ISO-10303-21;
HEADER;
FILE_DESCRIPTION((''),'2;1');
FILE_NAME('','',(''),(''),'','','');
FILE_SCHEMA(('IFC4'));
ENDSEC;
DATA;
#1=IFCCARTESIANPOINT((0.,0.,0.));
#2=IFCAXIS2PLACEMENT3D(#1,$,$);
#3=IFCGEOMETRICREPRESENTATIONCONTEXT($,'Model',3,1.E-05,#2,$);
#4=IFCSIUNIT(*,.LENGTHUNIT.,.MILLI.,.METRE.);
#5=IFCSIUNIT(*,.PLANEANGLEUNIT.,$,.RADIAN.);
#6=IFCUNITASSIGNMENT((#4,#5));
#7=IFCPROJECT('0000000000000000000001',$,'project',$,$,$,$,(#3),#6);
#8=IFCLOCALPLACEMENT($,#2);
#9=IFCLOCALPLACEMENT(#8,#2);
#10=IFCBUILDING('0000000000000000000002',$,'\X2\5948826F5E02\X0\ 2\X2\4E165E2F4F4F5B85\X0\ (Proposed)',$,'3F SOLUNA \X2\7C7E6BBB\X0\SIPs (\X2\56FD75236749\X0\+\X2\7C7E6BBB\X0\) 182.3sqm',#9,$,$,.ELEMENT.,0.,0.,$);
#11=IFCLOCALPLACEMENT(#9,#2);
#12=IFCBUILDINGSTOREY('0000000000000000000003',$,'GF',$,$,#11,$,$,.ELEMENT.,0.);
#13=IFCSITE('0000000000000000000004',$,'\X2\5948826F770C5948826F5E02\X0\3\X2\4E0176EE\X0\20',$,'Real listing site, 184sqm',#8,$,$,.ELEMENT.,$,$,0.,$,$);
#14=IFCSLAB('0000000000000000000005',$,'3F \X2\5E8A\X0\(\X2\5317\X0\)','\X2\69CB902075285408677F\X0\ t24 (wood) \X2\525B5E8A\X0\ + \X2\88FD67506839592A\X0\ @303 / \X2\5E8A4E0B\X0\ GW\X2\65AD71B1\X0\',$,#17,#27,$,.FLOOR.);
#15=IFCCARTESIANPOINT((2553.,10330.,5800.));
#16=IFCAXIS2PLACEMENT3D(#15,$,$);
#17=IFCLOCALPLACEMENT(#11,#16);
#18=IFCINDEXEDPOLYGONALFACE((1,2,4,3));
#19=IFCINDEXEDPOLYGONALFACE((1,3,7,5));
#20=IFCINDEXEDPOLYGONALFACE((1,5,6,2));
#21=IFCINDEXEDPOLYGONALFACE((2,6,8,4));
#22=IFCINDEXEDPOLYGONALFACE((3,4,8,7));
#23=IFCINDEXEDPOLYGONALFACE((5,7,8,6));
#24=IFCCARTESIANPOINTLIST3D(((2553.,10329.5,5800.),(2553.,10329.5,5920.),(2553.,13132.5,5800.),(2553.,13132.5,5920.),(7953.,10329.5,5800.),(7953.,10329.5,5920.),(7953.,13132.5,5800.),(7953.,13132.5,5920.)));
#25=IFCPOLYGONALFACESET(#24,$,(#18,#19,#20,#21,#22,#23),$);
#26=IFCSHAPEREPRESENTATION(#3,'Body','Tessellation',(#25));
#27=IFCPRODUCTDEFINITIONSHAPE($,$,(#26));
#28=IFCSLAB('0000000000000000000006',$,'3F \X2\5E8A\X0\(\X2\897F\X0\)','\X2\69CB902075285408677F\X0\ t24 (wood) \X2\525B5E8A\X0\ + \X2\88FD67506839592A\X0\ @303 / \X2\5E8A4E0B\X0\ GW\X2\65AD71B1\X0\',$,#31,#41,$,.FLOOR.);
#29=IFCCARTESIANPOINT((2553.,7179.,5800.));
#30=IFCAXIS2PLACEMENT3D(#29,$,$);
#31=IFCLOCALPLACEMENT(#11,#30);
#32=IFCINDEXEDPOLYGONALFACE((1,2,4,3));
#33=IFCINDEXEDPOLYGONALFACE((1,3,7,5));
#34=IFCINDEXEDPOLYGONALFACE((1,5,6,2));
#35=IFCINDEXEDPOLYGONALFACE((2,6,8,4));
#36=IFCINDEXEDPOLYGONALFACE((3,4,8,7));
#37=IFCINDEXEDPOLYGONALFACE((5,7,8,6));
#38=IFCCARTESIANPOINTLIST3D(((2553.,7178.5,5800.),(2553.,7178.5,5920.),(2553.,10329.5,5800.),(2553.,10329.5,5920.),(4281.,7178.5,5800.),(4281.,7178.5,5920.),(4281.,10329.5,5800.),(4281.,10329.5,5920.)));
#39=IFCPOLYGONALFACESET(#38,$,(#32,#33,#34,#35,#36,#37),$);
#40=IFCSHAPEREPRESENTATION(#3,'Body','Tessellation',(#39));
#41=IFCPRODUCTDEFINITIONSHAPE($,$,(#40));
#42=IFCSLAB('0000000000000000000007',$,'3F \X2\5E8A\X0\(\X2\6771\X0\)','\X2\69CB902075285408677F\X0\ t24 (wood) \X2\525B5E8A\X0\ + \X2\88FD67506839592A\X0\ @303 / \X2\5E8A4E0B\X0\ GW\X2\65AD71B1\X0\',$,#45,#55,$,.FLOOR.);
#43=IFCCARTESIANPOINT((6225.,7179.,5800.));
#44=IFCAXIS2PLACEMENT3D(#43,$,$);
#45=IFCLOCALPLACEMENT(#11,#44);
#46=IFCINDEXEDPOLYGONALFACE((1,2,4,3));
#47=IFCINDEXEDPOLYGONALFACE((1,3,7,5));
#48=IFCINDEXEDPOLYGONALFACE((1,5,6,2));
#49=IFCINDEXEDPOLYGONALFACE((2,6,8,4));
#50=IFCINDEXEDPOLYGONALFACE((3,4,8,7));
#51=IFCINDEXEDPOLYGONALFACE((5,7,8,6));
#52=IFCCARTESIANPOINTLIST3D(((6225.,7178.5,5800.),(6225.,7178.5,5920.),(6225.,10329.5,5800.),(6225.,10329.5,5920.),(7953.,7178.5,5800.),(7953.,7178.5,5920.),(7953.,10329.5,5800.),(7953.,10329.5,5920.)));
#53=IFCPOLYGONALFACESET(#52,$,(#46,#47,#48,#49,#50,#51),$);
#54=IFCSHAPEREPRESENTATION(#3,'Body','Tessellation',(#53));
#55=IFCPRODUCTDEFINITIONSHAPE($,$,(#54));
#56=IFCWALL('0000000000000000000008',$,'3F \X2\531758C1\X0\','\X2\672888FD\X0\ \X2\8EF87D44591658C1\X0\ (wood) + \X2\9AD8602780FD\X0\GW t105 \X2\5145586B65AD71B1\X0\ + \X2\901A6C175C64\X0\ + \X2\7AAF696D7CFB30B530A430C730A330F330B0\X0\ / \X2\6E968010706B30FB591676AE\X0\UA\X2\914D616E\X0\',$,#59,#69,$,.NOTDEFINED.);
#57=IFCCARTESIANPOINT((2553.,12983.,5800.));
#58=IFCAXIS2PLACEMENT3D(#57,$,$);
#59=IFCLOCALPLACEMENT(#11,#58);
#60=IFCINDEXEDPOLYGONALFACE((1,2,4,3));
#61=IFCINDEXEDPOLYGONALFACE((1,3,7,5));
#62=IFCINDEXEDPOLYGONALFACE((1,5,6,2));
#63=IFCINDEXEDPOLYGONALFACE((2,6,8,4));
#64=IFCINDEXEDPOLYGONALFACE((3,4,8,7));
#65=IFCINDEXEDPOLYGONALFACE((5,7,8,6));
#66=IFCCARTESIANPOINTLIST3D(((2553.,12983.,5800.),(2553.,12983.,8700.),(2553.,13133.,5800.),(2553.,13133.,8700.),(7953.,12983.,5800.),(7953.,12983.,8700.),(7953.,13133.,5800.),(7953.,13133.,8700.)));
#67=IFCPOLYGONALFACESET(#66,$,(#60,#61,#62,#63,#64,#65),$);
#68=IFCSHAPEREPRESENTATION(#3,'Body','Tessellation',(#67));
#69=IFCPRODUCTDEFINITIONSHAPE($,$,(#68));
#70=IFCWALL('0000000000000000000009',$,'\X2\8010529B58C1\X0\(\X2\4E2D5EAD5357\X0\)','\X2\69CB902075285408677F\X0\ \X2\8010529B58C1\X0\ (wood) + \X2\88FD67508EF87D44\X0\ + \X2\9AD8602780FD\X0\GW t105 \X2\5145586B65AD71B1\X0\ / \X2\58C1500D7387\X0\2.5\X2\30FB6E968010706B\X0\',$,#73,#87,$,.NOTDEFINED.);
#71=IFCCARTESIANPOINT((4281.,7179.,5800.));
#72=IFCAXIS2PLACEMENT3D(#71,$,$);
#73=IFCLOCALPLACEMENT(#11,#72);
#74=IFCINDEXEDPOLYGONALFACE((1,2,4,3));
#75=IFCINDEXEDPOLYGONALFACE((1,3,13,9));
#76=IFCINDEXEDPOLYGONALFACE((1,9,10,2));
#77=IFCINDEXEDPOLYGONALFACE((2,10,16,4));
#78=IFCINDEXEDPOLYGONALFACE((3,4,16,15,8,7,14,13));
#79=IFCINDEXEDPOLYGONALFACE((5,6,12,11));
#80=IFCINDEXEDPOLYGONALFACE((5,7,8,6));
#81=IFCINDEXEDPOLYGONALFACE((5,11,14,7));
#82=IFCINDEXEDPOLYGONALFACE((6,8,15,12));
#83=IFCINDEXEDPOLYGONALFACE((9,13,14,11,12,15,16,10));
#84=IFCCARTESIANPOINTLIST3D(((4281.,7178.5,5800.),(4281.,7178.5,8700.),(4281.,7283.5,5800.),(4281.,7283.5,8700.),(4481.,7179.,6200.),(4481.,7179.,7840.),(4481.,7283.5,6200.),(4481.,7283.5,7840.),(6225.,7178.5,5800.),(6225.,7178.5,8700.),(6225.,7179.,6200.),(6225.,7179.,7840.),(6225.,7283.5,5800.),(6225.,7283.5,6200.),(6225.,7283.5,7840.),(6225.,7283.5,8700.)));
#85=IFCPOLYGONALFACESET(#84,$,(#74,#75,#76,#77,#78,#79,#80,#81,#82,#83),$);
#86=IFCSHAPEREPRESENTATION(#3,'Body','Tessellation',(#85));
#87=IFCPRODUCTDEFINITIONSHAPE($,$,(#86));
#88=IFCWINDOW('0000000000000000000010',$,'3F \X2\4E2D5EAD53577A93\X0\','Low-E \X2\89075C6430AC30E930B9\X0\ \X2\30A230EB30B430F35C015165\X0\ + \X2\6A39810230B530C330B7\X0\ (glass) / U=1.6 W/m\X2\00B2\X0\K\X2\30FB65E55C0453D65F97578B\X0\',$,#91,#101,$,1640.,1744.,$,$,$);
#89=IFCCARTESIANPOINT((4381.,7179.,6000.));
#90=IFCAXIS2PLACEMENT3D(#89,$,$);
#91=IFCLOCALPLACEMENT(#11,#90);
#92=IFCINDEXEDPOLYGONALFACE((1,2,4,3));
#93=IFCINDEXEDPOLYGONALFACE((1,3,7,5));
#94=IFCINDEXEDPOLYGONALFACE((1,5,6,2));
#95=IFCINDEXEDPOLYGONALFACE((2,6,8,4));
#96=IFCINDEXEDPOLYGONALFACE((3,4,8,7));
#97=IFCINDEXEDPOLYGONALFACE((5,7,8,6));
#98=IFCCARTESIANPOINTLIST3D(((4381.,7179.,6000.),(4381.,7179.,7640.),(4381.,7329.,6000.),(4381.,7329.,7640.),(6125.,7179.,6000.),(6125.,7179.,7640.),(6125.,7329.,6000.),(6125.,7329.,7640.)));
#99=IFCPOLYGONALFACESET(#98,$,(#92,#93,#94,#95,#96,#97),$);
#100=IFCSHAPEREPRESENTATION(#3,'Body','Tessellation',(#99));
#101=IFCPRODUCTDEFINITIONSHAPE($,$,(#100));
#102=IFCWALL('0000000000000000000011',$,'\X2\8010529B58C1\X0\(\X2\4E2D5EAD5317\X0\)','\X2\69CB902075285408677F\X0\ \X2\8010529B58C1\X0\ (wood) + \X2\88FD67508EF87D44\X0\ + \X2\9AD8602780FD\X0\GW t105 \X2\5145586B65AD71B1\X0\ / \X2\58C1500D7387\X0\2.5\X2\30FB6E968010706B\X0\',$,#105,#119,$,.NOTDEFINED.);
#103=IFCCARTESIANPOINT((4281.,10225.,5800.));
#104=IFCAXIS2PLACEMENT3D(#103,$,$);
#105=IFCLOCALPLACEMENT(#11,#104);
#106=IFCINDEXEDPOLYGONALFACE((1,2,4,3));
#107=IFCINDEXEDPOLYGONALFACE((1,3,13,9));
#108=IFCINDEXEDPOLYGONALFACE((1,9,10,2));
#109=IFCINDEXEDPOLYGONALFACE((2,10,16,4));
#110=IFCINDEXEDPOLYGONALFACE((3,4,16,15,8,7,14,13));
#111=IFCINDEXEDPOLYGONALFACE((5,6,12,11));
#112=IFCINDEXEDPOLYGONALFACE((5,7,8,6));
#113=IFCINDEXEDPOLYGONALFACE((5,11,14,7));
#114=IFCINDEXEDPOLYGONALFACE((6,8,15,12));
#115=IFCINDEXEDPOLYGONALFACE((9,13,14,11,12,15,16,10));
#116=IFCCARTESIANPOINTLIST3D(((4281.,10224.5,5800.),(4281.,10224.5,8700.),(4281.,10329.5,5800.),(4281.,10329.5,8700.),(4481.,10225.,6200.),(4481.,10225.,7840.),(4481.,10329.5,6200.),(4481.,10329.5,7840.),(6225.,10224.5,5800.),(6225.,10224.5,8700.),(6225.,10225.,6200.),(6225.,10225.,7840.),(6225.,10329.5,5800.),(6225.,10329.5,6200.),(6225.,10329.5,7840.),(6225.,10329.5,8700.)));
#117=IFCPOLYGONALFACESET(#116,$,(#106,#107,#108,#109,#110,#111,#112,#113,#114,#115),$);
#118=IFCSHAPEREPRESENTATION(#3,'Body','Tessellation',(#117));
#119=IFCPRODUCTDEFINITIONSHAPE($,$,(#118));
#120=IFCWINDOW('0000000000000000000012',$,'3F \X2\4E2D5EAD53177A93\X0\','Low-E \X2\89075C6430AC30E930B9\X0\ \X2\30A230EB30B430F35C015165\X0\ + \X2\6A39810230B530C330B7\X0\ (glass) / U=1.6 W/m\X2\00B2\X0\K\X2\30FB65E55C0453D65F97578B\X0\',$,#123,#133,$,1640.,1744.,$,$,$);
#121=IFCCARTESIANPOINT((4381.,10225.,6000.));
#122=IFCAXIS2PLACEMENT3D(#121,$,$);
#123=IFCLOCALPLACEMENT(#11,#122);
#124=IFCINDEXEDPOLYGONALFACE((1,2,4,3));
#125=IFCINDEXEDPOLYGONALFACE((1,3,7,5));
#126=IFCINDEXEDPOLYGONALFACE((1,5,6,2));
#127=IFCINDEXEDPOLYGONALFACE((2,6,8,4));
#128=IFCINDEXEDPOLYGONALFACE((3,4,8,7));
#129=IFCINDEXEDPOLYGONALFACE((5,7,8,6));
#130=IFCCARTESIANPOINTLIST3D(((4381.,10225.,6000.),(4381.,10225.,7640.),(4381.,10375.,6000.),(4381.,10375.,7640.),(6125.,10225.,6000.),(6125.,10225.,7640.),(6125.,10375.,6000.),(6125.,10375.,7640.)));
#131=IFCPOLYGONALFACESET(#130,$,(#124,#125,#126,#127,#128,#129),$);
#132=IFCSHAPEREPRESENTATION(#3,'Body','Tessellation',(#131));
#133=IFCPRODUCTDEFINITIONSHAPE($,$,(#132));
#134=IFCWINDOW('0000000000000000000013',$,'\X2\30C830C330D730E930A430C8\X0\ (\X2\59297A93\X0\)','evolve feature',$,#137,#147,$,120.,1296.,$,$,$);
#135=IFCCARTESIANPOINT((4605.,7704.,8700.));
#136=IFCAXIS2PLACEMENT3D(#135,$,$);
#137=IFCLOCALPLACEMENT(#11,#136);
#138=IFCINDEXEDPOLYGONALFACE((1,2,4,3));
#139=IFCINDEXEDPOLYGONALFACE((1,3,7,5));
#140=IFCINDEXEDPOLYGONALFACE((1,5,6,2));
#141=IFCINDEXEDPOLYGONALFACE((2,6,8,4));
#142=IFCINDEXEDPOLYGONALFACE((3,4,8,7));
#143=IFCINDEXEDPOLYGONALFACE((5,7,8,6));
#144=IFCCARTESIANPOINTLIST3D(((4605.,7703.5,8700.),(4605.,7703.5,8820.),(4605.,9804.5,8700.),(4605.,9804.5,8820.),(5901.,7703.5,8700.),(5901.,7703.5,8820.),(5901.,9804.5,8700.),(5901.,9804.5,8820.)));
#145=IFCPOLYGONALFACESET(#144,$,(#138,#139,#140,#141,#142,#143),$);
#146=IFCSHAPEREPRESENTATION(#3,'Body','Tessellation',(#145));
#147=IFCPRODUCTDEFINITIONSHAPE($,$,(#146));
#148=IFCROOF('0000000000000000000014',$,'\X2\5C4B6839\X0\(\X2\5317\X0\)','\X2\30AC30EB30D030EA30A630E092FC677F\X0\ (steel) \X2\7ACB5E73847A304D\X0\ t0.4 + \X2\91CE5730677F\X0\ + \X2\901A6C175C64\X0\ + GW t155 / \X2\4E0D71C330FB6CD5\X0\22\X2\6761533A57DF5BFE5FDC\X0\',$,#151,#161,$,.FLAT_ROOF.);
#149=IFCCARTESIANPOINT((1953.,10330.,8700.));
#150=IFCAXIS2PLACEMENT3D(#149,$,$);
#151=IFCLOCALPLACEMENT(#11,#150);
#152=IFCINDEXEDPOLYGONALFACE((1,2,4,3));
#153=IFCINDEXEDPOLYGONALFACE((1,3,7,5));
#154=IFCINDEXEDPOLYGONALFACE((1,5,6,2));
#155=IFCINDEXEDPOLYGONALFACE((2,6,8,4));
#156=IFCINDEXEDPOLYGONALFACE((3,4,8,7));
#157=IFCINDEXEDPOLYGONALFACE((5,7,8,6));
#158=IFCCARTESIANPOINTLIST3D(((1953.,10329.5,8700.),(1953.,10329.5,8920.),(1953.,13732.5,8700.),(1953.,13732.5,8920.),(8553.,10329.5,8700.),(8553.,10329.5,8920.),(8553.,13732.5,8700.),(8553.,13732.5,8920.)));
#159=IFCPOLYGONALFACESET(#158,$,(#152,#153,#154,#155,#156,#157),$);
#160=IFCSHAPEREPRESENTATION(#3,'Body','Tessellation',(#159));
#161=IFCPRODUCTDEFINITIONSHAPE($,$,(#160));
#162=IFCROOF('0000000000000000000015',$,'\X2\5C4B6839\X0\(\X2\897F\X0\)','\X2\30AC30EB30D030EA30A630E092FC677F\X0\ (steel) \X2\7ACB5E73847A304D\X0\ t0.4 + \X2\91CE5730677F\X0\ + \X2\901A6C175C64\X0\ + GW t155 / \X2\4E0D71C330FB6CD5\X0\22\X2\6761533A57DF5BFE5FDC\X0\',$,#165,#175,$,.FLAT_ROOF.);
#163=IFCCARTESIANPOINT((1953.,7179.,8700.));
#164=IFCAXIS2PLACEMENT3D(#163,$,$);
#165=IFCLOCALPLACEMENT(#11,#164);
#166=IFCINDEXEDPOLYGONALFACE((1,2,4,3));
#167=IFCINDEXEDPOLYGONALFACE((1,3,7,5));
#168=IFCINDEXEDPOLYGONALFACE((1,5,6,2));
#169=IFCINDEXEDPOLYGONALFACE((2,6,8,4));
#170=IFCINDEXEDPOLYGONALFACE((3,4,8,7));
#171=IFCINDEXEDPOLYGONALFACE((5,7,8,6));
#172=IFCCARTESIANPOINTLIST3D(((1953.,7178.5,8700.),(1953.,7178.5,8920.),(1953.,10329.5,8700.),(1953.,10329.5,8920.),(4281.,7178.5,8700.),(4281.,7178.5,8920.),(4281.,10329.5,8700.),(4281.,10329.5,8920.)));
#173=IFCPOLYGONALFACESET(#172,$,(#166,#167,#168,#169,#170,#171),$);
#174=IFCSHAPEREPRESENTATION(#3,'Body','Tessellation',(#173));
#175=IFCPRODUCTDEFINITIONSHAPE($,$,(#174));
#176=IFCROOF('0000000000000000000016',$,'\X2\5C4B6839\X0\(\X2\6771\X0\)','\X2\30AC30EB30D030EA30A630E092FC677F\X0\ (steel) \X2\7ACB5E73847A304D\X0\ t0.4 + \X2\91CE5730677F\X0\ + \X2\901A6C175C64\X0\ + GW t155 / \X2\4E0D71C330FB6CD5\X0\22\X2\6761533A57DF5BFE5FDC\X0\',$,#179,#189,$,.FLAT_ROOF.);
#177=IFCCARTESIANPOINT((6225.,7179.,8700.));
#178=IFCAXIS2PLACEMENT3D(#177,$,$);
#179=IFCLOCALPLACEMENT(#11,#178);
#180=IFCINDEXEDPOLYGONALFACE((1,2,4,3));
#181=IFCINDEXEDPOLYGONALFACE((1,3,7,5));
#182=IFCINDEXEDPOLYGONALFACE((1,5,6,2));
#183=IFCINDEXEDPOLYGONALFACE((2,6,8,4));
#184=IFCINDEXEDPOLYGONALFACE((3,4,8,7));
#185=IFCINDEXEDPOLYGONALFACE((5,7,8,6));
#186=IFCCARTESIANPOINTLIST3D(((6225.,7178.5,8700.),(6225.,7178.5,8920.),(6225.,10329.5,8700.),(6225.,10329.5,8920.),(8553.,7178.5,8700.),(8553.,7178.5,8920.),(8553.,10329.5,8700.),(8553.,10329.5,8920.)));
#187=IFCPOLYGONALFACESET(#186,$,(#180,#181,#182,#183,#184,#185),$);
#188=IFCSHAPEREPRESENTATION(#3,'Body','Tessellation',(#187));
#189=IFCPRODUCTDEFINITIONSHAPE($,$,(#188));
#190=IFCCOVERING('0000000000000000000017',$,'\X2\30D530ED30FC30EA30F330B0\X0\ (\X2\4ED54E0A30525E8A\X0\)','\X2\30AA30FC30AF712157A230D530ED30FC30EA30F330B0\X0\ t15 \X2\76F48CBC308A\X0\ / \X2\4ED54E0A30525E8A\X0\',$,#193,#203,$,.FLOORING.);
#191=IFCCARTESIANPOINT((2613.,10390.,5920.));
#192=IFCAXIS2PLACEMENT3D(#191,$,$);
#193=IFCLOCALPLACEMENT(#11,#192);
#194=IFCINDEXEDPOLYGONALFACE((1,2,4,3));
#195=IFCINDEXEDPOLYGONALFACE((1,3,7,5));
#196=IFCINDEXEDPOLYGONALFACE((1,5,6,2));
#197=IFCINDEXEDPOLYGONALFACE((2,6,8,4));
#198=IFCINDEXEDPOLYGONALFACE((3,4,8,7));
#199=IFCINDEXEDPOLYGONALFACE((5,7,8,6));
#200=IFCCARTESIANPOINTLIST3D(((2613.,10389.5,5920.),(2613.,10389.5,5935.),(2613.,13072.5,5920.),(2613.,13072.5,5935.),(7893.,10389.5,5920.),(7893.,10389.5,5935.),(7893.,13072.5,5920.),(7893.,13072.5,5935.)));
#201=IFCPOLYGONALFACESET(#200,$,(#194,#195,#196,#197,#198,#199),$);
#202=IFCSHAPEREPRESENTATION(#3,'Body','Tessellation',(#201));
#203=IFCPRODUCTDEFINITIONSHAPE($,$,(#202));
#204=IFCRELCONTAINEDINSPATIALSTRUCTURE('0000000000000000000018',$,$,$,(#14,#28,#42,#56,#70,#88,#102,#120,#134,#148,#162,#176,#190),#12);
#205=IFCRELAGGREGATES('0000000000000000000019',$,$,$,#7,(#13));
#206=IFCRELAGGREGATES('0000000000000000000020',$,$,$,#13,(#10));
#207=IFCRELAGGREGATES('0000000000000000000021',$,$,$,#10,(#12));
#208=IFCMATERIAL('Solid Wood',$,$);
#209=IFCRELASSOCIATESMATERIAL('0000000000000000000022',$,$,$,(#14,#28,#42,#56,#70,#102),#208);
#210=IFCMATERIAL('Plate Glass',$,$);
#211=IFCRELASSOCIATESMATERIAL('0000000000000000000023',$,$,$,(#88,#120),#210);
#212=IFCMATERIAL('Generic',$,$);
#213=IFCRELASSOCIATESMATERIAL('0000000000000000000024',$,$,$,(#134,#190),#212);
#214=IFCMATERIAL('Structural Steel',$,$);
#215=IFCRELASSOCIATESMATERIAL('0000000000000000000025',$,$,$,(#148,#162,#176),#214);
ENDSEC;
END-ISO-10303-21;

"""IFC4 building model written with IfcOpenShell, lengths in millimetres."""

from ifc_helpers import new_model, si_unit, frame, frame_2d, origin, place, context, project, spatial, rectangle, extrude, material, element, fill, save


model = new_model("IFC4")

# Units and contexts
model_context = context("Model", 3, precision=1e-05, world=origin())
ifc_project = project(units=[si_unit("LENGTHUNIT", "METRE", prefix="MILLI"), si_unit("PLANEANGLEUNIT", "RADIAN")], contexts=[model_context])

# Site, building, storey
site_placement = place(None, origin())
site = spatial("IfcSite", under=ifc_project, at=site_placement, Name="奈良県奈良市3丁目20", ObjectType="Real listing site, 184sqm", CompositionType="ELEMENT", RefElevation=0.0)
building_placement = place(site_placement, origin())
building = spatial("IfcBuilding", under=site, at=building_placement, Name="奈良市 2世帯住宅 (Proposed)", ObjectType="3F SOLUNA 籾殻SIPs (国産杉+籾殻) 182.3sqm", CompositionType="ELEMENT", ElevationOfRefHeight=0.0, ElevationOfTerrain=0.0)
storey_placement = place(building_placement, origin())
storey = spatial("IfcBuildingStorey", under=building, at=storey_placement, Name="GF", CompositionType="ELEMENT", Elevation=0.0)

# Slabs
ifc_material_1 = material(Name="Solid Wood")
slab_1_placement = place(storey_placement, frame((2553.0, 10330.0, 5800.0)))
element("IfcSlab", 1, at=slab_1_placement, inside=storey, material=ifc_material_1, Name="3F 床(北)", Description="構造用合板 t24 (wood) 剛床 + 製材根太 @303 / 床下 GW断熱", PredefinedType="FLOOR", context=model_context, shape_type="SweptSolid", body=[
    extrude(rectangle(XDim=5400.0, YDim=2803.0, at=frame_2d((2700.0, 1401.0))), frame((2553.0, 10330.0, 5800.0)), (0.0, 0.0, 1.0), 120.0),
])
slab_2_placement = place(storey_placement, frame((2553.0, 7179.0, 5800.0)))
element("IfcSlab", 2, at=slab_2_placement, inside=storey, material=ifc_material_1, Name="3F 床(西)", Description="構造用合板 t24 (wood) 剛床 + 製材根太 @303 / 床下 GW断熱", PredefinedType="FLOOR", context=model_context, shape_type="SweptSolid", body=[
    extrude(rectangle(XDim=1728.0, YDim=3151.0, at=frame_2d((864.0, 1575.0))), frame((2553.0, 7179.0, 5800.0)), (0.0, 0.0, 1.0), 120.0),
])
slab_3_placement = place(storey_placement, frame((6225.0, 7179.0, 5800.0)))
element("IfcSlab", 3, at=slab_3_placement, inside=storey, material=ifc_material_1, Name="3F 床(東)", Description="構造用合板 t24 (wood) 剛床 + 製材根太 @303 / 床下 GW断熱", PredefinedType="FLOOR", context=model_context, shape_type="SweptSolid", body=[
    extrude(rectangle(XDim=1728.0, YDim=3151.0, at=frame_2d((864.0, 1575.0))), frame((6225.0, 7179.0, 5800.0)), (0.0, 0.0, 1.0), 120.0),
])

# Wall
wall_1_placement = place(storey_placement, frame((2553.0, 12983.0, 5800.0)))
element("IfcWall", 4, at=wall_1_placement, inside=storey, material=ifc_material_1, Name="3F 北壁", Description="木製 軸組外壁 (wood) + 高性能GW t105 充填断熱 + 通気層 + 窯業系サイディング / 準耐火・外皮UA配慮", PredefinedType="NOTDEFINED", context=model_context, shape_type="SweptSolid", body=[
    extrude(rectangle(XDim=5400.0, YDim=150.0, at=frame_2d((2700.0, 75.0))), frame((2553.0, 12983.0, 5800.0)), (0.0, 0.0, 1.0), 2900.0),
])

# Walls, openings, windows
wall_2_placement = place(storey_placement, frame((4281.0, 7179.0, 5800.0)))
wall_2 = element("IfcWall", 5, at=wall_2_placement, inside=storey, material=ifc_material_1, Name="耐力壁(中庭南)", Description="構造用合板 耐力壁 (wood) + 製材軸組 + 高性能GW t105 充填断熱 / 壁倍率2.5・準耐火", PredefinedType="NOTDEFINED", context=model_context, shape_type="SweptSolid", body=[
    extrude(rectangle(XDim=1944.0, YDim=105.0, at=frame_2d((972.0, 52.0))), frame((4281.0, 7179.0, 5800.0)), (0.0, 0.0, 1.0), 2900.0),
])
opening_1_placement = place(storey_placement, frame((4381.0, 7179.0, 6000.0)))
opening_1 = element("IfcOpeningElement", 6, at=opening_1_placement, cuts=wall_2, PredefinedType="NOTDEFINED", context=model_context, shape_type="SweptSolid", body=[
    extrude(rectangle(XDim=1744.0, YDim=150.0, at=frame_2d((872.0, 75.0))), frame((4381.0, 7179.0, 6000.0)), (0.0, 0.0, 1.0), 1640.0),
])
ifc_material_2 = material(Name="Plate Glass")
window_1_placement = place(storey_placement, frame((4381.0, 7179.0, 6000.0)))
window_1 = element("IfcWindow", 7, at=window_1_placement, inside=storey, material=ifc_material_2, Name="3F 中庭南窓", Description="Low-E 複層ガラス アルゴン封入 + 樹脂サッシ (glass) / U=1.6 W/m²K・日射取得型", OverallHeight=1640.0, OverallWidth=1744.0, context=model_context, shape_type="SweptSolid", body=[
    extrude(rectangle(XDim=1744.0, YDim=150.0, at=frame_2d((872.0, 75.0))), frame((4381.0, 7179.0, 6000.0)), (0.0, 0.0, 1.0), 1640.0),
])
fill(opening_1, window_1)
wall_3_placement = place(storey_placement, frame((4281.0, 10225.0, 5800.0)))
wall_3 = element("IfcWall", 8, at=wall_3_placement, inside=storey, material=ifc_material_1, Name="耐力壁(中庭北)", Description="構造用合板 耐力壁 (wood) + 製材軸組 + 高性能GW t105 充填断熱 / 壁倍率2.5・準耐火", PredefinedType="NOTDEFINED", context=model_context, shape_type="SweptSolid", body=[
    extrude(rectangle(XDim=1944.0, YDim=105.0, at=frame_2d((972.0, 52.0))), frame((4281.0, 10225.0, 5800.0)), (0.0, 0.0, 1.0), 2900.0),
])
opening_2_placement = place(storey_placement, frame((4381.0, 10225.0, 6000.0)))
opening_2 = element("IfcOpeningElement", 9, at=opening_2_placement, cuts=wall_3, PredefinedType="NOTDEFINED", context=model_context, shape_type="SweptSolid", body=[
    extrude(rectangle(XDim=1744.0, YDim=150.0, at=frame_2d((872.0, 75.0))), frame((4381.0, 10225.0, 6000.0)), (0.0, 0.0, 1.0), 1640.0),
])
window_2_placement = place(storey_placement, frame((4381.0, 10225.0, 6000.0)))
window_2 = element("IfcWindow", 10, at=window_2_placement, inside=storey, material=ifc_material_2, Name="3F 中庭北窓", Description="Low-E 複層ガラス アルゴン封入 + 樹脂サッシ (glass) / U=1.6 W/m²K・日射取得型", OverallHeight=1640.0, OverallWidth=1744.0, context=model_context, shape_type="SweptSolid", body=[
    extrude(rectangle(XDim=1744.0, YDim=150.0, at=frame_2d((872.0, 75.0))), frame((4381.0, 10225.0, 6000.0)), (0.0, 0.0, 1.0), 1640.0),
])
fill(opening_2, window_2)

# Window
ifc_material_3 = material(Name="Generic")
window_3_placement = place(storey_placement, frame((4605.0, 7704.0, 8700.0)))
element("IfcWindow", 11, at=window_3_placement, inside=storey, material=ifc_material_3, Name="トップライト (天窓)", Description="evolve feature", OverallHeight=120.0, OverallWidth=1296.0, context=model_context, shape_type="SweptSolid", body=[
    extrude(rectangle(XDim=1296.0, YDim=2101.0, at=frame_2d((648.0, 1050.0))), frame((4605.0, 7704.0, 8700.0)), (0.0, 0.0, 1.0), 120.0),
])

# Roofs
ifc_material_4 = material(Name="Structural Steel")
for number, where, name in (
    (12, (1953.0, 10330.0, 8700.0), "屋根(北)"),
):
    element("IfcRoof", number, at=place(storey_placement, frame(where)), inside=storey, material=ifc_material_4, Name=name, Description="ガルバリウム鋼板 (steel) 立平葺き t0.4 + 野地板 + 通気層 + GW t155 / 不燃・法22条区域対応", PredefinedType="FLAT_ROOF", context=model_context, shape_type="SweptSolid", body=[
        extrude(rectangle(XDim=6600.0, YDim=3403.0, at=frame_2d((3300.0, 1701.0))), frame((1953.0, 10330.0, 8700.0)), (0.0, 0.0, 1.0), 220.0),
    ])
roof_1_placement = place(storey_placement, frame((1953.0, 7179.0, 8700.0)))
element("IfcRoof", 13, at=roof_1_placement, inside=storey, material=ifc_material_4, Name="屋根(西)", Description="ガルバリウム鋼板 (steel) 立平葺き t0.4 + 野地板 + 通気層 + GW t155 / 不燃・法22条区域対応", PredefinedType="FLAT_ROOF", context=model_context, shape_type="SweptSolid", body=[
    extrude(rectangle(XDim=2328.0, YDim=3151.0, at=frame_2d((1164.0, 1575.0))), frame((1953.0, 7179.0, 8700.0)), (0.0, 0.0, 1.0), 220.0),
])
roof_2_placement = place(storey_placement, frame((6225.0, 7179.0, 8700.0)))
element("IfcRoof", 14, at=roof_2_placement, inside=storey, material=ifc_material_4, Name="屋根(東)", Description="ガルバリウム鋼板 (steel) 立平葺き t0.4 + 野地板 + 通気層 + GW t155 / 不燃・法22条区域対応", PredefinedType="FLAT_ROOF", context=model_context, shape_type="SweptSolid", body=[
    extrude(rectangle(XDim=2328.0, YDim=3151.0, at=frame_2d((1164.0, 1575.0))), frame((6225.0, 7179.0, 8700.0)), (0.0, 0.0, 1.0), 220.0),
])

# Covering
covering_1_placement = place(storey_placement, frame((2613.0, 10390.0, 5920.0)))
element("IfcCovering", 15, at=covering_1_placement, inside=storey, material=ifc_material_3, Name="フローリング (仕上げ床)", Description="オーク無垢フローリング t15 直貼り / 仕上げ床", PredefinedType="FLOORING", context=model_context, shape_type="SweptSolid", body=[
    extrude(rectangle(XDim=5280.0, YDim=2683.0, at=frame_2d((2640.0, 1341.0))), frame((2613.0, 10390.0, 5920.0)), (0.0, 0.0, 1.0), 15.0),
])

save(model, "model.ifc")
